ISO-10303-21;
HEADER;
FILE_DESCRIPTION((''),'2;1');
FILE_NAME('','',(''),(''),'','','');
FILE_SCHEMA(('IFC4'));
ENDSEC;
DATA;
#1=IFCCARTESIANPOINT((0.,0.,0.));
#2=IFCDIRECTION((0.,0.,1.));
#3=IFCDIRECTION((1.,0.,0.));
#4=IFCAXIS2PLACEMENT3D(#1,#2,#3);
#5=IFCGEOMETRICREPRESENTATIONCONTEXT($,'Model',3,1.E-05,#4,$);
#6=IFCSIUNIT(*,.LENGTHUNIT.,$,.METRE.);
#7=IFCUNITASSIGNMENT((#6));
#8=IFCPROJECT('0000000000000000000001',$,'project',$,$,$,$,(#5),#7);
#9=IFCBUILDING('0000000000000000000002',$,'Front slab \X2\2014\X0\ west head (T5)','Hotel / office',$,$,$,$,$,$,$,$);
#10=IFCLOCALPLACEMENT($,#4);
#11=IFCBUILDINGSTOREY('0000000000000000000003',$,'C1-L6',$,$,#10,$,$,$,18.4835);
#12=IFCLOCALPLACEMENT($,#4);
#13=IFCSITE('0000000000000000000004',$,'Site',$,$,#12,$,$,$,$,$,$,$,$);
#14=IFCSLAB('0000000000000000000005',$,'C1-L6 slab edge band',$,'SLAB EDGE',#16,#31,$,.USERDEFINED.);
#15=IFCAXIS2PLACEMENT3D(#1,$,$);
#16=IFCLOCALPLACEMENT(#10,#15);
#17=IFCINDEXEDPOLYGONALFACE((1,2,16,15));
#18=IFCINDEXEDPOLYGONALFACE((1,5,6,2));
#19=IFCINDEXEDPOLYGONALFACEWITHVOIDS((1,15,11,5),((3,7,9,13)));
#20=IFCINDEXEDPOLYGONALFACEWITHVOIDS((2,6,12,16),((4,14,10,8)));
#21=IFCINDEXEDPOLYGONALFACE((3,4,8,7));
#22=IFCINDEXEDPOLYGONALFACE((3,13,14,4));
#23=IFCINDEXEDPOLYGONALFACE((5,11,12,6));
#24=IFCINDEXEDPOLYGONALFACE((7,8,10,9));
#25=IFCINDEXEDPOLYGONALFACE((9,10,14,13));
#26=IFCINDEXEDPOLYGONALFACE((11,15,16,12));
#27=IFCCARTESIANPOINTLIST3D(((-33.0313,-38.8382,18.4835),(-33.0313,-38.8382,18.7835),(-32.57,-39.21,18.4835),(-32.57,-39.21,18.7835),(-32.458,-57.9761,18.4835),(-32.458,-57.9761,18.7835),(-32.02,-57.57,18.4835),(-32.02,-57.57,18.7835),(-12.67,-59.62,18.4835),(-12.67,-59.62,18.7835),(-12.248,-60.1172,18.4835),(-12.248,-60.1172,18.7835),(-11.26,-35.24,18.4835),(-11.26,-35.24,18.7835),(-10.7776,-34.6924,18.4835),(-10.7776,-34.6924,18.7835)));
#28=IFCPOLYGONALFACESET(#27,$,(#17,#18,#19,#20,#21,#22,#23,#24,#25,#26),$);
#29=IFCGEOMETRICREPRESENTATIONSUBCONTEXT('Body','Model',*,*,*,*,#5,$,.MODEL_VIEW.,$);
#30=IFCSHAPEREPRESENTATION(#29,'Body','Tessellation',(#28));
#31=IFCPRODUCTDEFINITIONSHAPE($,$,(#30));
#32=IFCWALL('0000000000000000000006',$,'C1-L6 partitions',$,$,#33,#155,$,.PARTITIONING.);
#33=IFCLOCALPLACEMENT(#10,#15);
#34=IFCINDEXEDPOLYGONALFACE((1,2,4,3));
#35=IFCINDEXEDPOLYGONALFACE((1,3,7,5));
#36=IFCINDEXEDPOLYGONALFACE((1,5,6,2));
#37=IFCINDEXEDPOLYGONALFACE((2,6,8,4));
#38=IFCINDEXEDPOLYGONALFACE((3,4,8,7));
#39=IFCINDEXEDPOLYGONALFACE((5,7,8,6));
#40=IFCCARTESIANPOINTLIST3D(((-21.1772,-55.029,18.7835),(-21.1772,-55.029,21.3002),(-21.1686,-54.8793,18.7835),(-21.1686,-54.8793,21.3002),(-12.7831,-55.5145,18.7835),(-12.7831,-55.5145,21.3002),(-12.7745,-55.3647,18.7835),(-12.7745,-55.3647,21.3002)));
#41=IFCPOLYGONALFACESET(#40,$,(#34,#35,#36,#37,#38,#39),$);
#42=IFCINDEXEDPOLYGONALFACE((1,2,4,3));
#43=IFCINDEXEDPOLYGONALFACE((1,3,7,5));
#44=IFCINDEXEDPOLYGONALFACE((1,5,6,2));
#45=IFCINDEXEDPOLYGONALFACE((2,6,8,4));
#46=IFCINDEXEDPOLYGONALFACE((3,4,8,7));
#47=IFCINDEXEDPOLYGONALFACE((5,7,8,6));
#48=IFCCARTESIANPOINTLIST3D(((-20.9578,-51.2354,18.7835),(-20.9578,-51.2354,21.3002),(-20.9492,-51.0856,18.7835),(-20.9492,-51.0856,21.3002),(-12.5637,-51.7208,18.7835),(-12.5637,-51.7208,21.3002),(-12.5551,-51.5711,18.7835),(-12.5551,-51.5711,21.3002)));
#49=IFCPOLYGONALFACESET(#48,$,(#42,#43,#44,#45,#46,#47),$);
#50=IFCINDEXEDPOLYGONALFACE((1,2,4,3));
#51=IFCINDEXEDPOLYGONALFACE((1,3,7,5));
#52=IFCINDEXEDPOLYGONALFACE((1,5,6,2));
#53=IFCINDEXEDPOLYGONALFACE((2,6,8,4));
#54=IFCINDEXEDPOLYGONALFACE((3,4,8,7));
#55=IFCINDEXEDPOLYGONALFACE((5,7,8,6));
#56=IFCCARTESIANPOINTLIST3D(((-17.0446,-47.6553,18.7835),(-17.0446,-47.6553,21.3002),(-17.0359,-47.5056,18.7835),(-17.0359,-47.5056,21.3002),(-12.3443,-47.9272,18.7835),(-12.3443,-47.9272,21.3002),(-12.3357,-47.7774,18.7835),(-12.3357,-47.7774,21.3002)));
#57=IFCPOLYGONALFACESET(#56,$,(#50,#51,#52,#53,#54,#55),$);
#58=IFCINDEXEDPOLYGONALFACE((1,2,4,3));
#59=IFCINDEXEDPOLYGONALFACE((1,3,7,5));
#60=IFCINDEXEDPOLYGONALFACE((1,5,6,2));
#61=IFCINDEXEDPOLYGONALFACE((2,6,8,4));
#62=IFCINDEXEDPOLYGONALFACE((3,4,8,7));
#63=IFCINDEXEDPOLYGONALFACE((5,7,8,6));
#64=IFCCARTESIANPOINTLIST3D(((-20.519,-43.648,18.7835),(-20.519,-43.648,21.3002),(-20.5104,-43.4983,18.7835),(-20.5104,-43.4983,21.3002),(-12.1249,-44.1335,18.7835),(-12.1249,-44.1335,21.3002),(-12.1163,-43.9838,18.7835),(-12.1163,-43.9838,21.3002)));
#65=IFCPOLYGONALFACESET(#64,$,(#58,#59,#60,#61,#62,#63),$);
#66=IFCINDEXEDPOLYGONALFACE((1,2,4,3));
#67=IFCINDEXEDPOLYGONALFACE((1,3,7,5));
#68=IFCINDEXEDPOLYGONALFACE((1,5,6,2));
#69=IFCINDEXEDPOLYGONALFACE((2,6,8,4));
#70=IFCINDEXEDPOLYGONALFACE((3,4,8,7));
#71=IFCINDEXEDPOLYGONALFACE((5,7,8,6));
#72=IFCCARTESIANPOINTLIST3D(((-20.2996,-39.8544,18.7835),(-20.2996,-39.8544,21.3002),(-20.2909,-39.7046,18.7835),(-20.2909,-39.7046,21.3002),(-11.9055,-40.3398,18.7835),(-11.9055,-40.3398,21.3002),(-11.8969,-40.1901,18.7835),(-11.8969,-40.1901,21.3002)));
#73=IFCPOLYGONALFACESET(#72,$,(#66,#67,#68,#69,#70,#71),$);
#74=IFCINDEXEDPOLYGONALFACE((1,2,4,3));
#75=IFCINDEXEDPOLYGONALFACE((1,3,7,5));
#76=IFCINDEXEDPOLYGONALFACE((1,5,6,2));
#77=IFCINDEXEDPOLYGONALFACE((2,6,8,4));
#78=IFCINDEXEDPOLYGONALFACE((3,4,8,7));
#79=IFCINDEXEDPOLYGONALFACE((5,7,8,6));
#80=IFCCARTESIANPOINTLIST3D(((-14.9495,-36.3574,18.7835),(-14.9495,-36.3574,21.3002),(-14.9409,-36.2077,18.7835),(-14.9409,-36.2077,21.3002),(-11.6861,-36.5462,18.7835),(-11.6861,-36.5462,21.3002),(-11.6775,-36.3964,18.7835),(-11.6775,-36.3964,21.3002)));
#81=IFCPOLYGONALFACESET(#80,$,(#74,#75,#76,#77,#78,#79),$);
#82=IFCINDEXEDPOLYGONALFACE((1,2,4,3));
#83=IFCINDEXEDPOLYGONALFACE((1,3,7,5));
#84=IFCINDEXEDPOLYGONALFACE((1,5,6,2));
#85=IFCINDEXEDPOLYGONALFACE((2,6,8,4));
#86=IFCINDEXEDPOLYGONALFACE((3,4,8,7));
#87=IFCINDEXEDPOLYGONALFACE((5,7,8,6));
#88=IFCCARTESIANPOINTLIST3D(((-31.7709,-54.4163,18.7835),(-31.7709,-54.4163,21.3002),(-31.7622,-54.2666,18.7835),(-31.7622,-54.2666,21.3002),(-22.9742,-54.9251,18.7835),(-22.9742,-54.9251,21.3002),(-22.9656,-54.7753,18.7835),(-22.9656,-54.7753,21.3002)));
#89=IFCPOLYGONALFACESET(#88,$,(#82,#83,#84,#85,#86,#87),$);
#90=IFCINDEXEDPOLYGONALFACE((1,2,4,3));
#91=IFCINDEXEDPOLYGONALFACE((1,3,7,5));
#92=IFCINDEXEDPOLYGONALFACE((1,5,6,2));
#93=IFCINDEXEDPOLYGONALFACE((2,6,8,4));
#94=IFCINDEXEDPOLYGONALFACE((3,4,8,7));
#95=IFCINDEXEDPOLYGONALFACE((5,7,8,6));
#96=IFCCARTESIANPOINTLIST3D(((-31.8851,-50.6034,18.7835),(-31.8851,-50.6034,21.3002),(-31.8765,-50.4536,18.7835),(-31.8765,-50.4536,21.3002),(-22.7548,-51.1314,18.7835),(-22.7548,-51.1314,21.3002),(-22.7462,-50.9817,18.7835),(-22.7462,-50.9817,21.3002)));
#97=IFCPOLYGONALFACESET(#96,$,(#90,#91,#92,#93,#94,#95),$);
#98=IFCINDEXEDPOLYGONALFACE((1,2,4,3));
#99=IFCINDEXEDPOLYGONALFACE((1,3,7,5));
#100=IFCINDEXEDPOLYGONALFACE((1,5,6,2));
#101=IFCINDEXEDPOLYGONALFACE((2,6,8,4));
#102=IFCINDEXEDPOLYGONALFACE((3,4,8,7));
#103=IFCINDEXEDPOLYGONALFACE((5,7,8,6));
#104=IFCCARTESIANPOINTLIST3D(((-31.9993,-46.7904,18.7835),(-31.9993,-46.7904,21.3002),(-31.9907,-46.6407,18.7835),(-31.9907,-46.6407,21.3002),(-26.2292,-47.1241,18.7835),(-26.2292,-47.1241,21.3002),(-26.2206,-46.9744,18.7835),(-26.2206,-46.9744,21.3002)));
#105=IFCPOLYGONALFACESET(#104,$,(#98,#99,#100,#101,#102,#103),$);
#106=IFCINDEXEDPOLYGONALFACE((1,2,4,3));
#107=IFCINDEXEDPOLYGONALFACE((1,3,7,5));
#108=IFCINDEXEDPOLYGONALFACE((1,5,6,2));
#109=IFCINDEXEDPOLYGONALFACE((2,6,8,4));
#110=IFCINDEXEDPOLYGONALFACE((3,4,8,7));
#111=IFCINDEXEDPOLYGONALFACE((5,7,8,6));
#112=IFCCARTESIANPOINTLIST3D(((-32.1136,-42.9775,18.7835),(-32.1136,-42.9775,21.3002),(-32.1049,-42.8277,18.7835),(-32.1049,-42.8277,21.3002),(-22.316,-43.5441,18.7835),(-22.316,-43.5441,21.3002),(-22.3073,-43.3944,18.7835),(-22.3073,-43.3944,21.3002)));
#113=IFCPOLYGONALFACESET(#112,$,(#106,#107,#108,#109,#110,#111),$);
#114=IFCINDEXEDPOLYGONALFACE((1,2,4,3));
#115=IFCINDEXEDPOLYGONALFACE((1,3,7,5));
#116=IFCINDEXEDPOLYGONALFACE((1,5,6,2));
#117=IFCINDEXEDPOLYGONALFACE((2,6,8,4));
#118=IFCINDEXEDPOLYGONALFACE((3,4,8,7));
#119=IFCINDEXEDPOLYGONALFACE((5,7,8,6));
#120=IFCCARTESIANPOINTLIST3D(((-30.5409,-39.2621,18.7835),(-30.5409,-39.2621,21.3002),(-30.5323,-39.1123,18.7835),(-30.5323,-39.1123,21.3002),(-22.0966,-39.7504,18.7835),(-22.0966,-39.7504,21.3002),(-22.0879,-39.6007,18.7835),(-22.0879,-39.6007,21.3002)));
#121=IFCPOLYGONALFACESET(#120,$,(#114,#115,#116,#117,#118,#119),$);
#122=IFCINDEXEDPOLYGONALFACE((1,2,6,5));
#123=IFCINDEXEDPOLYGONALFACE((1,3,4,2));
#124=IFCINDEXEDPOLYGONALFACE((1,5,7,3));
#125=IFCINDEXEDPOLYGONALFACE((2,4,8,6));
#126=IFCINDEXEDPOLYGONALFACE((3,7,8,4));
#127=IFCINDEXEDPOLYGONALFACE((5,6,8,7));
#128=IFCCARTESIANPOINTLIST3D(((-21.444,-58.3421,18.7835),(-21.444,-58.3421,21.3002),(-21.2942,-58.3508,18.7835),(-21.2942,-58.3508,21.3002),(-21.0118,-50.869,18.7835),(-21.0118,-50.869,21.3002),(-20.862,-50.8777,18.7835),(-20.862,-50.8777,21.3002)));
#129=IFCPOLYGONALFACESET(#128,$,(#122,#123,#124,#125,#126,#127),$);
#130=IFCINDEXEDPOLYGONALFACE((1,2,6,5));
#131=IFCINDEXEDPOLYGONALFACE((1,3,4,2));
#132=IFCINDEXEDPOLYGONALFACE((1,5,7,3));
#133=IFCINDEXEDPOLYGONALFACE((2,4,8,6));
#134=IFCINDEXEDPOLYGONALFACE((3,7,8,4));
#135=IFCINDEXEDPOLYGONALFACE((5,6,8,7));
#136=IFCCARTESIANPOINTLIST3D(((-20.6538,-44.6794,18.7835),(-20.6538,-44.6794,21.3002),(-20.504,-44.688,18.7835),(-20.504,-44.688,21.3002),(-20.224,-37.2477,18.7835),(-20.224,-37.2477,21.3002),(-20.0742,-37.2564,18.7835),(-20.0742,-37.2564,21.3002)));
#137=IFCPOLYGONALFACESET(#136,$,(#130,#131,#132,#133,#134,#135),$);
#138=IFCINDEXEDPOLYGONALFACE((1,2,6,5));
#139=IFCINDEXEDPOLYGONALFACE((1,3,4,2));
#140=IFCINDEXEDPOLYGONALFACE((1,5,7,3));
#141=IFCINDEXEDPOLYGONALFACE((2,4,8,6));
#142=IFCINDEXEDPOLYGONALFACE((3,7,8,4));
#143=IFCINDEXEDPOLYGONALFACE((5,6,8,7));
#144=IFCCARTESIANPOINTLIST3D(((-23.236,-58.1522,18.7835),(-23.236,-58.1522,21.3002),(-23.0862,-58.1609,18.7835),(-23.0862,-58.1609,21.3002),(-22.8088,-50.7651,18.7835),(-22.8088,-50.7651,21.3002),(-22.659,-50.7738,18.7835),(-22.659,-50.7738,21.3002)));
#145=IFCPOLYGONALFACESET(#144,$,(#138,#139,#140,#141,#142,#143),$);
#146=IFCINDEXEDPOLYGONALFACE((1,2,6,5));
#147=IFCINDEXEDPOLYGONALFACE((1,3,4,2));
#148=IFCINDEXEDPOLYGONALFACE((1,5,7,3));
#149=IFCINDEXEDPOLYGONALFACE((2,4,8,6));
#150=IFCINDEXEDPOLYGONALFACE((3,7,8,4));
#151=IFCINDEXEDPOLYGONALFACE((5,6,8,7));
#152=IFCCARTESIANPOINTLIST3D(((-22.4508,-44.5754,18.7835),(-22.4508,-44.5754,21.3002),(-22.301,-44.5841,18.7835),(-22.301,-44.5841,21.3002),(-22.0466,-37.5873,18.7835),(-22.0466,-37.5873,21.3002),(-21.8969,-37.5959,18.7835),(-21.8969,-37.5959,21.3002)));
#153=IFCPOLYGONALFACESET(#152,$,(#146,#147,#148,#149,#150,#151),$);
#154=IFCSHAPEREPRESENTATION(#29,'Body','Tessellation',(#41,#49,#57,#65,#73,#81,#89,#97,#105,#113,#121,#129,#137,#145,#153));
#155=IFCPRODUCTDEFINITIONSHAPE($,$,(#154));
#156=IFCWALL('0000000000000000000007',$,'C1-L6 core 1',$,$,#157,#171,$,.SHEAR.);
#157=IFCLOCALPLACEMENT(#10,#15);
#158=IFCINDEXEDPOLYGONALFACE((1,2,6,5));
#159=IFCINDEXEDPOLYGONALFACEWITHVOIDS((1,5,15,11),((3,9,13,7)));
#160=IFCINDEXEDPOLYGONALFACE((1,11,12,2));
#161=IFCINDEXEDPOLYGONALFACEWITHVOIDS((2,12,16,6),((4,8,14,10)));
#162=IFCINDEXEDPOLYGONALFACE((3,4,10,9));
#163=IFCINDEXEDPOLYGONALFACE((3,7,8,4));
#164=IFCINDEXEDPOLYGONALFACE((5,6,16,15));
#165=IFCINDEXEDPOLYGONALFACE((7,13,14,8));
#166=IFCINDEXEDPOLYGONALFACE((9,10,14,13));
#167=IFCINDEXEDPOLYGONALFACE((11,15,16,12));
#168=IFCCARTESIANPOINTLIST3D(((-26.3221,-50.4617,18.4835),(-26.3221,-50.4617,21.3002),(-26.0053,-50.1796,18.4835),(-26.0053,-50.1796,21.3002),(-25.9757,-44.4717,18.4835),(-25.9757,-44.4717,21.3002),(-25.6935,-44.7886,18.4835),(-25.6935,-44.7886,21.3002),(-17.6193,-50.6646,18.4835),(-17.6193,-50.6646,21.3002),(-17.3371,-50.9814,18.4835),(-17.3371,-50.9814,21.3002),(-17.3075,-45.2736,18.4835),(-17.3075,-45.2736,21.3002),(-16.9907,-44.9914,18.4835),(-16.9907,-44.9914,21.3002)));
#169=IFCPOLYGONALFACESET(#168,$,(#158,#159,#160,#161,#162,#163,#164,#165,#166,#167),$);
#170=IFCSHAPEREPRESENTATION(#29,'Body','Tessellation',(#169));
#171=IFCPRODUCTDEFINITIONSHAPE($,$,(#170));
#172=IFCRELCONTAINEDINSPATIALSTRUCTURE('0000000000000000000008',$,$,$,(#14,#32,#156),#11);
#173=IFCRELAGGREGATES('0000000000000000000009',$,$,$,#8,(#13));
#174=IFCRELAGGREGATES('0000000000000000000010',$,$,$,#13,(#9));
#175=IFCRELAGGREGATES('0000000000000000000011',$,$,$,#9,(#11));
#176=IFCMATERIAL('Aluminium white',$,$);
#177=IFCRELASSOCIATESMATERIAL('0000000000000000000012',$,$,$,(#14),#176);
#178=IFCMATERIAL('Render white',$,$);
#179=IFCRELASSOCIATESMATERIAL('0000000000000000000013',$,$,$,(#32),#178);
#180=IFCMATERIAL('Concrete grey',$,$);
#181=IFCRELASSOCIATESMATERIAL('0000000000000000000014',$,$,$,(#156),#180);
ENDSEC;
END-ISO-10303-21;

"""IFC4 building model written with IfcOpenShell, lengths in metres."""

from ifc_helpers import new_model, si_unit, frame, origin_with_axes, place, context, subcontext, project, spatial, polyline, outline, extrude, material, element, save


model = new_model("IFC4")

# Units and contexts
model_context = context("Model", 3, precision=1e-05, world=origin_with_axes())
body_context = subcontext(model_context, "Body", "Model", "MODEL_VIEW")
ifc_project = project(units=[si_unit("LENGTHUNIT", "METRE")], contexts=[model_context])

# Site, building, storey
site_placement = place(None, origin_with_axes())
site = spatial("IfcSite", under=ifc_project, at=site_placement, Name="Site")
building = spatial("IfcBuilding", under=site, Name="Front slab — west head (T5)", Description="Hotel / office")
storey_placement = place(None, origin_with_axes())
storey = spatial("IfcBuildingStorey", under=building, at=storey_placement, Name="C1-L6", Elevation=18.4835)

# Shared definitions
ifc_material_1 = material(Name="Aluminium white")

# Slab
slab_placement = place(storey_placement, origin_with_axes())
element("IfcSlab", 1, at=slab_placement, inside=storey, material=ifc_material_1, Name="C1-L6 slab edge band", ObjectType="SLAB EDGE", PredefinedType="USERDEFINED", context=body_context, shape_type="SweptSolid", body=[
    extrude(outline(polyline([(-33.0313, -38.8382), (-32.458, -57.9761), (-12.248, -60.1172), (-10.7776, -34.6924), (-33.0313, -38.8382)]), holes=[polyline([(-32.57, -39.21), (-32.02, -57.57), (-12.67, -59.62), (-11.26, -35.24), (-32.57, -39.21)])]), frame((0.0, 0.0, 18.4835), z_axis=(0.0, 0.0, 1.0), x_axis=(1.0, 0.0, 0.0)), (0.0, 0.0, 1.0), 0.3),
])

# Walls
ifc_material_2 = material(Name="Render white")
wall_1_placement = place(storey_placement, origin_with_axes())
element("IfcWall", 2, at=wall_1_placement, inside=storey, material=ifc_material_2, Name="C1-L6 partitions", PredefinedType="PARTITIONING", context=body_context, shape_type="SweptSolid", body=[
    extrude(outline(polyline([(-12.7745, -55.3647), (-21.1686, -54.8793), (-21.1772, -55.029), (-12.7831, -55.5145), (-12.7745, -55.3647)])), frame((0.0, 0.0, 18.7835), z_axis=(0.0, 0.0, 1.0), x_axis=(1.0, 0.0, 0.0)), (0.0, 0.0, 1.0), 2.5167),
    extrude(outline(polyline([(-12.5551, -51.5711), (-20.9492, -51.0856), (-20.9578, -51.2354), (-12.5637, -51.7208), (-12.5551, -51.5711)])), frame((0.0, 0.0, 18.7835), z_axis=(0.0, 0.0, 1.0), x_axis=(1.0, 0.0, 0.0)), (0.0, 0.0, 1.0), 2.5167),
    extrude(outline(polyline([(-12.3357, -47.7774), (-17.0359, -47.5056), (-17.0446, -47.6553), (-12.3443, -47.9272), (-12.3357, -47.7774)])), frame((0.0, 0.0, 18.7835), z_axis=(0.0, 0.0, 1.0), x_axis=(1.0, 0.0, 0.0)), (0.0, 0.0, 1.0), 2.5167),
    extrude(outline(polyline([(-12.1163, -43.9838), (-20.5104, -43.4983), (-20.519, -43.648), (-12.1249, -44.1335), (-12.1163, -43.9838)])), frame((0.0, 0.0, 18.7835), z_axis=(0.0, 0.0, 1.0), x_axis=(1.0, 0.0, 0.0)), (0.0, 0.0, 1.0), 2.5167),
    extrude(outline(polyline([(-11.8969, -40.1901), (-20.2909, -39.7046), (-20.2996, -39.8544), (-11.9055, -40.3398), (-11.8969, -40.1901)])), frame((0.0, 0.0, 18.7835), z_axis=(0.0, 0.0, 1.0), x_axis=(1.0, 0.0, 0.0)), (0.0, 0.0, 1.0), 2.5167),
    extrude(outline(polyline([(-11.6775, -36.3964), (-14.9409, -36.2077), (-14.9495, -36.3574), (-11.6861, -36.5462), (-11.6775, -36.3964)])), frame((0.0, 0.0, 18.7835), z_axis=(0.0, 0.0, 1.0), x_axis=(1.0, 0.0, 0.0)), (0.0, 0.0, 1.0), 2.5167),
    extrude(outline(polyline([(-22.9656, -54.7753), (-31.7622, -54.2666), (-31.7709, -54.4163), (-22.9742, -54.9251), (-22.9656, -54.7753)])), frame((0.0, 0.0, 18.7835), z_axis=(0.0, 0.0, 1.0), x_axis=(1.0, 0.0, 0.0)), (0.0, 0.0, 1.0), 2.5167),
    extrude(outline(polyline([(-22.7462, -50.9817), (-31.8765, -50.4536), (-31.8851, -50.6034), (-22.7548, -51.1314), (-22.7462, -50.9817)])), frame((0.0, 0.0, 18.7835), z_axis=(0.0, 0.0, 1.0), x_axis=(1.0, 0.0, 0.0)), (0.0, 0.0, 1.0), 2.5167),
    extrude(outline(polyline([(-26.2206, -46.9744), (-31.9907, -46.6407), (-31.9993, -46.7904), (-26.2292, -47.1241), (-26.2206, -46.9744)])), frame((0.0, 0.0, 18.7835), z_axis=(0.0, 0.0, 1.0), x_axis=(1.0, 0.0, 0.0)), (0.0, 0.0, 1.0), 2.5167),
    extrude(outline(polyline([(-22.3073, -43.3944), (-32.1049, -42.8277), (-32.1136, -42.9775), (-22.316, -43.5441), (-22.3073, -43.3944)])), frame((0.0, 0.0, 18.7835), z_axis=(0.0, 0.0, 1.0), x_axis=(1.0, 0.0, 0.0)), (0.0, 0.0, 1.0), 2.5167),
    extrude(outline(polyline([(-22.0879, -39.6007), (-30.5323, -39.1123), (-30.5409, -39.2621), (-22.0966, -39.7504), (-22.0879, -39.6007)])), frame((0.0, 0.0, 18.7835), z_axis=(0.0, 0.0, 1.0), x_axis=(1.0, 0.0, 0.0)), (0.0, 0.0, 1.0), 2.5167),
    extrude(outline(polyline([(-21.2942, -58.3508), (-20.862, -50.8777), (-21.0118, -50.869), (-21.444, -58.3421), (-21.2942, -58.3508)])), frame((0.0, 0.0, 18.7835), z_axis=(0.0, 0.0, 1.0), x_axis=(1.0, 0.0, 0.0)), (0.0, 0.0, 1.0), 2.5167),
    extrude(outline(polyline([(-20.504, -44.688), (-20.0742, -37.2564), (-20.224, -37.2477), (-20.6538, -44.6794), (-20.504, -44.688)])), frame((0.0, 0.0, 18.7835), z_axis=(0.0, 0.0, 1.0), x_axis=(1.0, 0.0, 0.0)), (0.0, 0.0, 1.0), 2.5167),
    extrude(outline(polyline([(-23.0862, -58.1609), (-22.659, -50.7738), (-22.8088, -50.7651), (-23.236, -58.1522), (-23.0862, -58.1609)])), frame((0.0, 0.0, 18.7835), z_axis=(0.0, 0.0, 1.0), x_axis=(1.0, 0.0, 0.0)), (0.0, 0.0, 1.0), 2.5167),
    extrude(outline(polyline([(-22.301, -44.5841), (-21.8969, -37.5959), (-22.0466, -37.5873), (-22.4508, -44.5754), (-22.301, -44.5841)])), frame((0.0, 0.0, 18.7835), z_axis=(0.0, 0.0, 1.0), x_axis=(1.0, 0.0, 0.0)), (0.0, 0.0, 1.0), 2.5167),
])
ifc_material_3 = material(Name="Concrete grey")
wall_2_placement = place(storey_placement, origin_with_axes())
element("IfcWall", 3, at=wall_2_placement, inside=storey, material=ifc_material_3, Name="C1-L6 core 1", PredefinedType="SHEAR", context=body_context, shape_type="SweptSolid", body=[
    extrude(outline(polyline([(-17.3371, -50.9814), (-16.9907, -44.9914), (-25.9757, -44.4717), (-26.3221, -50.4617), (-17.3371, -50.9814)]), holes=[polyline([(-17.6193, -50.6646), (-17.3075, -45.2736), (-25.6935, -44.7886), (-26.0053, -50.1796), (-17.6193, -50.6646)])]), frame((0.0, 0.0, 18.4835), z_axis=(0.0, 0.0, 1.0), x_axis=(1.0, 0.0, 0.0)), (0.0, 0.0, 1.0), 2.8167),
])

save(model, "model.ifc")
